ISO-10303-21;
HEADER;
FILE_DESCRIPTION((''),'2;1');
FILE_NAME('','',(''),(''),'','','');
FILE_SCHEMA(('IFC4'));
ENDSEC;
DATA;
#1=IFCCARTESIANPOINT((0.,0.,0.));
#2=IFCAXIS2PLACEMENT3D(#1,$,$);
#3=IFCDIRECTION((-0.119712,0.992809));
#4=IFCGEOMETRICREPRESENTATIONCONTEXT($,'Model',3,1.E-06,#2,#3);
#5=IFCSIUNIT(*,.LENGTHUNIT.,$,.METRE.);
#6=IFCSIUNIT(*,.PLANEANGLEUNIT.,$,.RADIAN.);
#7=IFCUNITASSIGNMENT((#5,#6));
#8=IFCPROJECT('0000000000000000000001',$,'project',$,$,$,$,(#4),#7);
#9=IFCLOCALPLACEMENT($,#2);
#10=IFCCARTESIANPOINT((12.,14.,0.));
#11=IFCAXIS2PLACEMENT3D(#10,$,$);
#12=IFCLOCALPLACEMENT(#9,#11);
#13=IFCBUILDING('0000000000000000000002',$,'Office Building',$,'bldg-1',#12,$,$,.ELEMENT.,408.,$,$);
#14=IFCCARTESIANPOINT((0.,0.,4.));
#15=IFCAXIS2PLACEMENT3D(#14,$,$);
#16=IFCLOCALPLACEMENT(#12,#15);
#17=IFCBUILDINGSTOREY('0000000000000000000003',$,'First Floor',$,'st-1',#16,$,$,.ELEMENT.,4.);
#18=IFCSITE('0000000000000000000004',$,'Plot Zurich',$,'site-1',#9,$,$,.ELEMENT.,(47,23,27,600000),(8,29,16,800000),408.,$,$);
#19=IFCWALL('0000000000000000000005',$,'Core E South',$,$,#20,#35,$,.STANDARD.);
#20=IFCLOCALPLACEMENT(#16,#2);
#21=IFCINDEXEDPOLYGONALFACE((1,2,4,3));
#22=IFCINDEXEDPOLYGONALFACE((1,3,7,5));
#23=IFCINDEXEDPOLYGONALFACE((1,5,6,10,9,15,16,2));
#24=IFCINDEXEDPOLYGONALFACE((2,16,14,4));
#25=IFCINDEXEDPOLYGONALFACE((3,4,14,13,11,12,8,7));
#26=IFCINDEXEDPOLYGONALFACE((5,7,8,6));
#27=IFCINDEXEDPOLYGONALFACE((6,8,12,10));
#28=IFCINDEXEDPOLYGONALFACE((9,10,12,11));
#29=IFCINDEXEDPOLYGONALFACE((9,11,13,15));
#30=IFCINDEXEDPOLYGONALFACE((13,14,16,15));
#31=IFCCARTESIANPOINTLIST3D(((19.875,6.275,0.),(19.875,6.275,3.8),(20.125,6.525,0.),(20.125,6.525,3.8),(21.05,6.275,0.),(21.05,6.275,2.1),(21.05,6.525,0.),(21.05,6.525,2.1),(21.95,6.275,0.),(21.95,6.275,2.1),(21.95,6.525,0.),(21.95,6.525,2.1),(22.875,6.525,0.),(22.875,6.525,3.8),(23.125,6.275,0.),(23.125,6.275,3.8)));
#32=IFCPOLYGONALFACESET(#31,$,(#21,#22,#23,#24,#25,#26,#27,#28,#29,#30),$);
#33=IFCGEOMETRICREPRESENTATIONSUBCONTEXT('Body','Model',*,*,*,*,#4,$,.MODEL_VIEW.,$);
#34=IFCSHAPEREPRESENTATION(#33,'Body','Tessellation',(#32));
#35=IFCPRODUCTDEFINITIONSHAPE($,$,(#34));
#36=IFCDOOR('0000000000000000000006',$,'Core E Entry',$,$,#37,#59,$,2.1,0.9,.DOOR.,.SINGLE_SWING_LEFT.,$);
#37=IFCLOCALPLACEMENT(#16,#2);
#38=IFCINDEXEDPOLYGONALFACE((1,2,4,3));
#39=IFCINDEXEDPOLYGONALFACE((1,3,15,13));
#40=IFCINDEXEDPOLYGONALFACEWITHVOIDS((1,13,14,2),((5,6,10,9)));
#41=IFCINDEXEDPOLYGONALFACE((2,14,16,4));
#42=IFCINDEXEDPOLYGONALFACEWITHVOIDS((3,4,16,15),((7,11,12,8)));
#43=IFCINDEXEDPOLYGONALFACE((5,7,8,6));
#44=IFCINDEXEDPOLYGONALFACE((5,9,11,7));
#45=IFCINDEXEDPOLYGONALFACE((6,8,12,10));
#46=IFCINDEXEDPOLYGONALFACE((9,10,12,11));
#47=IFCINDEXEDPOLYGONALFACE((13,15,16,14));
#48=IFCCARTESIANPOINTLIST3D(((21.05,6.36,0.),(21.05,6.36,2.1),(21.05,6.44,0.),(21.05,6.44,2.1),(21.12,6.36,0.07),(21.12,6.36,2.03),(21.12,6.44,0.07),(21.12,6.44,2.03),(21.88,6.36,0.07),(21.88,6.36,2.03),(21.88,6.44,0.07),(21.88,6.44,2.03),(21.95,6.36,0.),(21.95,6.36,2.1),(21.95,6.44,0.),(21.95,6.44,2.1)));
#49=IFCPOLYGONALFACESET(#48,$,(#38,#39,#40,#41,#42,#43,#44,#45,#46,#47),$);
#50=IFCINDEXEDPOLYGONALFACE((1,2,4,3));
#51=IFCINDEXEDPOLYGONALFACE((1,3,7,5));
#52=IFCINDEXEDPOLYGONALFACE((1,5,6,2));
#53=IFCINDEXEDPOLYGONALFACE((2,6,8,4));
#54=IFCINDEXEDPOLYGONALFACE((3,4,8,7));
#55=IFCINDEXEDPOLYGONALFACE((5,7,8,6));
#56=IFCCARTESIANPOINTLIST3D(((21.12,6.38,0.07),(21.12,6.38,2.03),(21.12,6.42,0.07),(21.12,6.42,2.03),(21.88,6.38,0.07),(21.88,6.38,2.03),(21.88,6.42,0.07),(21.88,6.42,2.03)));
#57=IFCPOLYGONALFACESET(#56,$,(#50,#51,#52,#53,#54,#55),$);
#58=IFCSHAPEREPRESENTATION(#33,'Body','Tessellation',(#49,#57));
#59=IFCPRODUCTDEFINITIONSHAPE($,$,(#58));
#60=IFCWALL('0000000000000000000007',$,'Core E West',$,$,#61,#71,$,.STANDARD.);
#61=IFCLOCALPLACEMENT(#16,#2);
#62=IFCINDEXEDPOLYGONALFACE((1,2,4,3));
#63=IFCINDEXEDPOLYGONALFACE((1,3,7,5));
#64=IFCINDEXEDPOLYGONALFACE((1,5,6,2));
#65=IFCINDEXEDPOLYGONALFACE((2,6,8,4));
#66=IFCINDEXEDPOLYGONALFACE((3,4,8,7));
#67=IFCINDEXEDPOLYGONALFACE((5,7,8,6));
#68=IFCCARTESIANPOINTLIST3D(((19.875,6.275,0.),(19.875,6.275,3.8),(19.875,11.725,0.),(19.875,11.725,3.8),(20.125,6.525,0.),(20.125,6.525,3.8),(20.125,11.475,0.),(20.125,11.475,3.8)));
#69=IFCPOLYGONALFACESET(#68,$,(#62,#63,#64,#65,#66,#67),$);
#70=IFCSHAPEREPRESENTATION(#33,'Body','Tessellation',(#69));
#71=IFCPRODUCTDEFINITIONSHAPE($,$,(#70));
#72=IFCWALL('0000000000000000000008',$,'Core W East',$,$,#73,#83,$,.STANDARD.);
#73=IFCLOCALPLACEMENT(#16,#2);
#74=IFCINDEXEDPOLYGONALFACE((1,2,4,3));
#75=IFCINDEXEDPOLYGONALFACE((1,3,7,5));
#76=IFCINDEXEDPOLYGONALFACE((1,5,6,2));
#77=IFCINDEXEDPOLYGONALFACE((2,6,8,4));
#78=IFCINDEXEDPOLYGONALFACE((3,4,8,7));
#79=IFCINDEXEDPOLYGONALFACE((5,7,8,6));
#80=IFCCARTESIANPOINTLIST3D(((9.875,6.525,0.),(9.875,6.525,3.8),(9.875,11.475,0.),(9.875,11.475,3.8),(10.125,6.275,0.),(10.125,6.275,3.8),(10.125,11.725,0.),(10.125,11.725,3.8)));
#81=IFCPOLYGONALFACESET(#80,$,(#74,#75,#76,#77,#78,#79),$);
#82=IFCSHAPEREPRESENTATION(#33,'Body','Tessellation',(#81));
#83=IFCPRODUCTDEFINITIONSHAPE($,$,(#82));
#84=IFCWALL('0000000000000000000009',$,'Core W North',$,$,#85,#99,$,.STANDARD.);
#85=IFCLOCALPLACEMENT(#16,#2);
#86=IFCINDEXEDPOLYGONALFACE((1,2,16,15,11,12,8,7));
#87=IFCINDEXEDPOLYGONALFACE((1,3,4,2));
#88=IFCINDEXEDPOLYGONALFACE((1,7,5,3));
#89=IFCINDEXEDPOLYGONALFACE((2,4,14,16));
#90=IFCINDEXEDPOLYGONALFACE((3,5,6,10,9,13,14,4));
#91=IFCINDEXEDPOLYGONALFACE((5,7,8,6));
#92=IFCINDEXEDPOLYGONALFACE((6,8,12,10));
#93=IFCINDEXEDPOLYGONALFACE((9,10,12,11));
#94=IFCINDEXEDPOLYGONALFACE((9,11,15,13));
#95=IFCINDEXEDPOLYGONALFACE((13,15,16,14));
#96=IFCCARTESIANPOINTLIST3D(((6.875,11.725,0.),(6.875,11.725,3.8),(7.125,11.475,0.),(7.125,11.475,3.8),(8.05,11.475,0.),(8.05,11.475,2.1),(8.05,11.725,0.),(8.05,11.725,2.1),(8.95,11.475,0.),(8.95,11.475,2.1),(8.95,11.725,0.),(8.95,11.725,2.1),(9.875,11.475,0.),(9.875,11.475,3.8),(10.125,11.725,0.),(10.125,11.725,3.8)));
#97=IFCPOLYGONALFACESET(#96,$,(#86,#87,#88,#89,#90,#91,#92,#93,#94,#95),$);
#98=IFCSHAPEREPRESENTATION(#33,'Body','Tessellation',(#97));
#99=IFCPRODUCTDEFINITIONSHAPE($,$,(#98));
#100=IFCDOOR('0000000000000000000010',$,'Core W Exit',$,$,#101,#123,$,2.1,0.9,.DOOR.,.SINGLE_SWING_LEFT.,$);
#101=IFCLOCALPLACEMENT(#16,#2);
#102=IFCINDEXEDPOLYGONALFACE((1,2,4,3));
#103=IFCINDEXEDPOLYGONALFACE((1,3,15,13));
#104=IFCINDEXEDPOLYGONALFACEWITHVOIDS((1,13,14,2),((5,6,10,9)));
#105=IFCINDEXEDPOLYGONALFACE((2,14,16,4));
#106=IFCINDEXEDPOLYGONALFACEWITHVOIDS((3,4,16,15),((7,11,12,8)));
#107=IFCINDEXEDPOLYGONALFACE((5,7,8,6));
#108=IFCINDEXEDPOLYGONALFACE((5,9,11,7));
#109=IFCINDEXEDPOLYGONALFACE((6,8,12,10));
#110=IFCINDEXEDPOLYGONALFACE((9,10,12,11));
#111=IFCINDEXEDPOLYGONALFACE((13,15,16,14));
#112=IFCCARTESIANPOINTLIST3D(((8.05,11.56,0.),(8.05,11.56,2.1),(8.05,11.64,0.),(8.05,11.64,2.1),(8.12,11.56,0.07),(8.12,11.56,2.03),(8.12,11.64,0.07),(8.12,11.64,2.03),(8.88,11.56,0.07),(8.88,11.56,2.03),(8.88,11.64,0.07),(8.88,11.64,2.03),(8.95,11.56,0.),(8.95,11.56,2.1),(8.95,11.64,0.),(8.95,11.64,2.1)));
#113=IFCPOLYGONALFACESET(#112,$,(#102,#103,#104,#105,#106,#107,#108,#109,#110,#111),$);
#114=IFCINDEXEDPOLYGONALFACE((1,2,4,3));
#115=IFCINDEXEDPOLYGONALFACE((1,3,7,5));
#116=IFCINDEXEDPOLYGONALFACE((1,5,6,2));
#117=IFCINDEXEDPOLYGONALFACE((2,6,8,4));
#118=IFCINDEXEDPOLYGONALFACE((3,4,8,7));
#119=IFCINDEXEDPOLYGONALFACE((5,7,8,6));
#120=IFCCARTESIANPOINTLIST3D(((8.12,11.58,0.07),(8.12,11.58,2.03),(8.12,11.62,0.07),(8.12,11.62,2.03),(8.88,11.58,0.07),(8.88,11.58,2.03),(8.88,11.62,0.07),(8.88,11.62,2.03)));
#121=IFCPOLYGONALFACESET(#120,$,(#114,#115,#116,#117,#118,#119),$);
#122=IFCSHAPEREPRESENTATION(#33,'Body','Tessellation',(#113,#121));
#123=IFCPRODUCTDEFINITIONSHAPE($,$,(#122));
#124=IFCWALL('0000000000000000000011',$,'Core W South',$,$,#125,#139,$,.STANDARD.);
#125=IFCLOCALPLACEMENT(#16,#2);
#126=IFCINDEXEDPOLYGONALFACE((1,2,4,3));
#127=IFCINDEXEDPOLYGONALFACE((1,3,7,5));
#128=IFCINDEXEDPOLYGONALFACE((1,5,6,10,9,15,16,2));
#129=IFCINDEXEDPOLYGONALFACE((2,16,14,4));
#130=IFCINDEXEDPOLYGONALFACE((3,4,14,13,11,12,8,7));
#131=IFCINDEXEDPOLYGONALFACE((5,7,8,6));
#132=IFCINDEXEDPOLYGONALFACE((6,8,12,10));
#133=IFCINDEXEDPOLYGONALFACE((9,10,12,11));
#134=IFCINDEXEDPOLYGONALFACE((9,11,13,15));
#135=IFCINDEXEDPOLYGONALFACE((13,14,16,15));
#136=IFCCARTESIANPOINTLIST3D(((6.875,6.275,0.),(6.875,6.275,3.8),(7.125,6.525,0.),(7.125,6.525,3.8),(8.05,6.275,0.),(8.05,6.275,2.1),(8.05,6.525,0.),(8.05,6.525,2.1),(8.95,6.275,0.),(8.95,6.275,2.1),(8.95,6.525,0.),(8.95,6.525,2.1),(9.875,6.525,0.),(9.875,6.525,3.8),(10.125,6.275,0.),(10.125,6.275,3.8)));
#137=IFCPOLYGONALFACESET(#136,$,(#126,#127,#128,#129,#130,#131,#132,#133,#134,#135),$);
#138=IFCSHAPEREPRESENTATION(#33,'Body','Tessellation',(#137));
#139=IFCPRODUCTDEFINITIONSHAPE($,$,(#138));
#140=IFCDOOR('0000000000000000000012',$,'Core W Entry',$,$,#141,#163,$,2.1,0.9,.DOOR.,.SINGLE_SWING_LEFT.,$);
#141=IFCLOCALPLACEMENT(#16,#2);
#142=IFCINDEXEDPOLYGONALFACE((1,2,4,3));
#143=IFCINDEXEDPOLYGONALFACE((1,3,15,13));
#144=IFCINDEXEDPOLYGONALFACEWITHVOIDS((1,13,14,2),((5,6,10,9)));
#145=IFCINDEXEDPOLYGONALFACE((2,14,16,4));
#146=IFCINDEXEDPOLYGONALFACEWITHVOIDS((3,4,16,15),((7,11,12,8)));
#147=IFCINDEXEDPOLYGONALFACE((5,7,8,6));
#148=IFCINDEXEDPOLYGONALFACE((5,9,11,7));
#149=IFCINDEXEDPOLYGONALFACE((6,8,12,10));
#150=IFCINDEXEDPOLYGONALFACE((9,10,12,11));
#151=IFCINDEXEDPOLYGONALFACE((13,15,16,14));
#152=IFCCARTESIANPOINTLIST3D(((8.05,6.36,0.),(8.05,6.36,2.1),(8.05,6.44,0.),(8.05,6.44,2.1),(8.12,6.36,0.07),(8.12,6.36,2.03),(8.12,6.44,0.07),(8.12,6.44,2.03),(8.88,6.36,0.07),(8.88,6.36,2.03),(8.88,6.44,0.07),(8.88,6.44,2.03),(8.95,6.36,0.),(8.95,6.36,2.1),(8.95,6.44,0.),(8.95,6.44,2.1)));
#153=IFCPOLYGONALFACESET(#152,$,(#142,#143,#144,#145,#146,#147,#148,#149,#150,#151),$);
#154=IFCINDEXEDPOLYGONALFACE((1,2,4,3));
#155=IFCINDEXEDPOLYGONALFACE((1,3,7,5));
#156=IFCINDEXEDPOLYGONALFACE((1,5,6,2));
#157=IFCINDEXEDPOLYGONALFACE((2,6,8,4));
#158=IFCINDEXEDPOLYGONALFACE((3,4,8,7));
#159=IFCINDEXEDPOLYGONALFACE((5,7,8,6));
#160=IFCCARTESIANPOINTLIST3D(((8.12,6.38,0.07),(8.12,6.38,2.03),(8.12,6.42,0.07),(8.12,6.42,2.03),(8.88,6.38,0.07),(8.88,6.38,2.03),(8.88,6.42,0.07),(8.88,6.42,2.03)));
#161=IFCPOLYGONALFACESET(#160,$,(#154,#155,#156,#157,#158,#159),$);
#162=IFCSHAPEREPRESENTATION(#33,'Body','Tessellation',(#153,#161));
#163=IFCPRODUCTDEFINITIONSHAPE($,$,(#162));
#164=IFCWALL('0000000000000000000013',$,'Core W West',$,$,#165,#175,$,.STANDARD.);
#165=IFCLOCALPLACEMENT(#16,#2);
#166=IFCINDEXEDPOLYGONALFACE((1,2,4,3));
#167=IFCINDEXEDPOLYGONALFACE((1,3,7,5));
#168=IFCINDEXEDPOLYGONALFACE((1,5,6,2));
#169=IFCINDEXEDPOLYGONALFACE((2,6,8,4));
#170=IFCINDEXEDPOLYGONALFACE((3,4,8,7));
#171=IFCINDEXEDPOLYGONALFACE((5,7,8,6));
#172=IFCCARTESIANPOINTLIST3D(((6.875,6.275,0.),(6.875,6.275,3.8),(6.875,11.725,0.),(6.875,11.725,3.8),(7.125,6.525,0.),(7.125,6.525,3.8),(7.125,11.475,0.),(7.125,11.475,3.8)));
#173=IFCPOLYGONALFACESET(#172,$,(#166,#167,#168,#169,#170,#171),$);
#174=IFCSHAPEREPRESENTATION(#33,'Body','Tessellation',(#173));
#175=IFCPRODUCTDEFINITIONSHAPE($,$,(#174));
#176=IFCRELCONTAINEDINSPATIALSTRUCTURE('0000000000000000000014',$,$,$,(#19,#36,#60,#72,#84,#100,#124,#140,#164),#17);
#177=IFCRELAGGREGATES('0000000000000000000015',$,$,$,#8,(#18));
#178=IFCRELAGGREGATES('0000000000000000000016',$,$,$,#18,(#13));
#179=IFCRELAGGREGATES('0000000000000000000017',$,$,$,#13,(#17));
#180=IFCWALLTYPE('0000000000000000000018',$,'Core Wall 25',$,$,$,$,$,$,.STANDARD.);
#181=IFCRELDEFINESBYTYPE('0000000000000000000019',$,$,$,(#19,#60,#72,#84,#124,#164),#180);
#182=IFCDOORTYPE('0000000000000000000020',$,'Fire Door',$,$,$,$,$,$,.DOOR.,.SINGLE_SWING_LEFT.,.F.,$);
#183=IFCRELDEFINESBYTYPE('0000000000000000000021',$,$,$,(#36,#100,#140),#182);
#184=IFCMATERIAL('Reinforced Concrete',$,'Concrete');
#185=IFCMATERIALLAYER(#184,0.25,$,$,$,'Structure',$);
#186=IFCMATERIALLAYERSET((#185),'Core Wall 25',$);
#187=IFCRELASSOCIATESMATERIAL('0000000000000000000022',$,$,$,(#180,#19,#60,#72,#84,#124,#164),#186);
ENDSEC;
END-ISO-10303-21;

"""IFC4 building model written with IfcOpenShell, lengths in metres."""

from ifc_helpers import new_model, si_unit, direction, frame, frame_2d, origin, origin_2d, place, context, subcontext, project, spatial, polyline, rectangle, outline, extrude, material, layer, layer_set, layer_usage, type_object, element, fill, save


model = new_model("IFC4")

# Units and contexts
model_context = context("Model", 3, precision=1e-06, world=origin(), true_north=direction((-0.119712, 0.992809)))
body_context = subcontext(model_context, "Body", "Model", "MODEL_VIEW")
ifc_project = project(units=[si_unit("LENGTHUNIT", "METRE"), si_unit("PLANEANGLEUNIT", "RADIAN")], contexts=[model_context])

# Site, building, storey
site_placement = place(None, origin())
site = spatial("IfcSite", under=ifc_project, at=site_placement, Name="Plot Zurich", ObjectType="site-1", CompositionType="ELEMENT", RefLatitude=(47, 23, 27, 600000), RefLongitude=(8, 29, 16, 800000), RefElevation=408.0)
building_placement = place(site_placement, frame((12.0, 14.0, 0.0)))
building = spatial("IfcBuilding", under=site, at=building_placement, Name="Office Building", ObjectType="bldg-1", CompositionType="ELEMENT", ElevationOfRefHeight=408.0)
storey_placement = place(building_placement, frame((0.0, 0.0, 4.0)))
storey = spatial("IfcBuildingStorey", under=building, at=storey_placement, Name="First Floor", ObjectType="st-1", CompositionType="ELEMENT", Elevation=4.0)

# Shared definitions
ifc_material_1 = material(Name="Reinforced Concrete", Category="Concrete")

# Shared definitions
ifc_layer_1 = layer(ifc_material_1, 0.25, Category="Structure")
ifc_layer_set_1 = layer_set([ifc_layer_1], Name="Core Wall 25")
wall_type_1 = type_object("IfcWallType", Name="Core Wall 25", PredefinedType="STANDARD", material=ifc_layer_set_1)

# Wall, opening, door
door_type = type_object("IfcDoorType", Name="Fire Door", OperationType="SINGLE_SWING_LEFT", ParameterTakesPrecedence=False, PredefinedType="DOOR")
ifc_layer_usage_1 = layer_usage(ifc_layer_set_1, "AXIS2", "NEGATIVE", 0.125)
wall_1_placement = place(storey_placement, origin())
wall_1 = element("IfcWall", 1, at=wall_1_placement, inside=storey, type_object=wall_type_1, material=ifc_layer_usage_1, Name="Core E South", PredefinedType="STANDARD", context=body_context, shape_type="SweptSolid", body=[
    extrude(outline(polyline([(19.875, 6.275), (23.125, 6.275), (22.875, 6.525), (20.125, 6.525), (19.875, 6.275)])), origin(), (0.0, 0.0, 1.0), 3.8),
])
opening_1_placement = place(wall_1_placement, frame((21.5, 6.4, 0.0), z_axis=(0.0, 0.0, 1.0), x_axis=(1.0, 0.0, 0.0)))
opening_1 = element("IfcOpeningElement", 2, at=opening_1_placement, cuts=wall_1, PredefinedType="OPENING", context=body_context, shape_type="SweptSolid", body=[
    extrude(rectangle(XDim=0.9, YDim=0.25, at=origin_2d()), origin(), (0.0, 0.0, 1.0), 2.1),
])
door_1_placement = place(opening_1_placement, frame((0.0, 0.0, 0.0), z_axis=(0.0, -1.0, 0.0), x_axis=(1.0, 0.0, 0.0)))
door_1 = element("IfcDoor", 3, at=door_1_placement, inside=storey, type_object=door_type, Name="Core E Entry", OperationType="SINGLE_SWING_LEFT", OverallHeight=2.1, OverallWidth=0.9, PredefinedType="DOOR", context=body_context, shape_type="SweptSolid", body=[
    extrude(outline(polyline([(-0.45, 0.0), (0.45, 0.0), (0.45, 2.1), (-0.45, 2.1), (-0.45, 0.0)]), holes=[polyline([(-0.38, 0.07), (0.38, 0.07), (0.38, 2.03), (-0.38, 2.03), (-0.38, 0.07)])]), frame((0.0, 0.0, -0.04)), (0.0, 0.0, 1.0), 0.08),
    extrude(rectangle(XDim=0.76, YDim=1.96, at=frame_2d((0.0, 1.05))), frame((0.0, 0.0, -0.02)), (0.0, 0.0, 1.0), 0.04),
])
fill(opening_1, door_1)

# Walls
ifc_layer_usage_2 = layer_usage(ifc_layer_set_1, "AXIS2", "NEGATIVE", 0.125)
wall_2_placement = place(storey_placement, origin())
element("IfcWall", 4, at=wall_2_placement, inside=storey, type_object=wall_type_1, material=ifc_layer_usage_2, Name="Core E West", PredefinedType="STANDARD", context=body_context, shape_type="SweptSolid", body=[
    extrude(outline(polyline([(19.875, 11.725), (19.875, 6.275), (20.125, 6.525), (20.125, 11.475), (19.875, 11.725)])), origin(), (0.0, 0.0, 1.0), 3.8),
])
ifc_layer_usage_3 = layer_usage(ifc_layer_set_1, "AXIS2", "NEGATIVE", 0.125)
wall_3_placement = place(storey_placement, origin())
element("IfcWall", 5, at=wall_3_placement, inside=storey, type_object=wall_type_1, material=ifc_layer_usage_3, Name="Core W East", PredefinedType="STANDARD", context=body_context, shape_type="SweptSolid", body=[
    extrude(outline(polyline([(10.125, 6.275), (10.125, 11.725), (9.875, 11.475), (9.875, 6.525), (10.125, 6.275)])), origin(), (0.0, 0.0, 1.0), 3.8),
])

# Walls, openings, doors
ifc_layer_usage_4 = layer_usage(ifc_layer_set_1, "AXIS2", "NEGATIVE", 0.125)
wall_4_placement = place(storey_placement, origin())
wall_4 = element("IfcWall", 6, at=wall_4_placement, inside=storey, type_object=wall_type_1, material=ifc_layer_usage_4, Name="Core W North", PredefinedType="STANDARD", context=body_context, shape_type="SweptSolid", body=[
    extrude(outline(polyline([(10.125, 11.725), (6.875, 11.725), (7.125, 11.475), (9.875, 11.475), (10.125, 11.725)])), origin(), (0.0, 0.0, 1.0), 3.8),
])
opening_2_placement = place(wall_4_placement, frame((8.5, 11.6, 0.0), z_axis=(0.0, 0.0, 1.0), x_axis=(-1.0, 0.0, 0.0)))
opening_2 = element("IfcOpeningElement", 7, at=opening_2_placement, cuts=wall_4, PredefinedType="OPENING", context=body_context, shape_type="SweptSolid", body=[
    extrude(rectangle(XDim=0.9, YDim=0.25, at=origin_2d()), origin(), (0.0, 0.0, 1.0), 2.1),
])
door_2_placement = place(opening_2_placement, frame((0.0, 0.0, 0.0), z_axis=(0.0, -1.0, 0.0), x_axis=(1.0, 0.0, 0.0)))
door_2 = element("IfcDoor", 8, at=door_2_placement, inside=storey, type_object=door_type, Name="Core W Exit", OperationType="SINGLE_SWING_LEFT", OverallHeight=2.1, OverallWidth=0.9, PredefinedType="DOOR", context=body_context, shape_type="SweptSolid", body=[
    extrude(outline(polyline([(-0.45, 0.0), (0.45, 0.0), (0.45, 2.1), (-0.45, 2.1), (-0.45, 0.0)]), holes=[polyline([(-0.38, 0.07), (0.38, 0.07), (0.38, 2.03), (-0.38, 2.03), (-0.38, 0.07)])]), frame((0.0, 0.0, -0.04)), (0.0, 0.0, 1.0), 0.08),
    extrude(rectangle(XDim=0.76, YDim=1.96, at=frame_2d((0.0, 1.05))), frame((0.0, 0.0, -0.02)), (0.0, 0.0, 1.0), 0.04),
])
fill(opening_2, door_2)
ifc_layer_usage_5 = layer_usage(ifc_layer_set_1, "AXIS2", "NEGATIVE", 0.125)
wall_5_placement = place(storey_placement, origin())
wall_5 = element("IfcWall", 9, at=wall_5_placement, inside=storey, type_object=wall_type_1, material=ifc_layer_usage_5, Name="Core W South", PredefinedType="STANDARD", context=body_context, shape_type="SweptSolid", body=[
    extrude(outline(polyline([(6.875, 6.275), (10.125, 6.275), (9.875, 6.525), (7.125, 6.525), (6.875, 6.275)])), origin(), (0.0, 0.0, 1.0), 3.8),
])
opening_3_placement = place(wall_5_placement, frame((8.5, 6.4, 0.0), z_axis=(0.0, 0.0, 1.0), x_axis=(1.0, 0.0, 0.0)))
opening_3 = element("IfcOpeningElement", 10, at=opening_3_placement, cuts=wall_5, PredefinedType="OPENING", context=body_context, shape_type="SweptSolid", body=[
    extrude(rectangle(XDim=0.9, YDim=0.25, at=origin_2d()), origin(), (0.0, 0.0, 1.0), 2.1),
])
door_3_placement = place(opening_3_placement, frame((0.0, 0.0, 0.0), z_axis=(0.0, -1.0, 0.0), x_axis=(1.0, 0.0, 0.0)))
door_3 = element("IfcDoor", 11, at=door_3_placement, inside=storey, type_object=door_type, Name="Core W Entry", OperationType="SINGLE_SWING_LEFT", OverallHeight=2.1, OverallWidth=0.9, PredefinedType="DOOR", context=body_context, shape_type="SweptSolid", body=[
    extrude(outline(polyline([(-0.45, 0.0), (0.45, 0.0), (0.45, 2.1), (-0.45, 2.1), (-0.45, 0.0)]), holes=[polyline([(-0.38, 0.07), (0.38, 0.07), (0.38, 2.03), (-0.38, 2.03), (-0.38, 0.07)])]), frame((0.0, 0.0, -0.04)), (0.0, 0.0, 1.0), 0.08),
    extrude(rectangle(XDim=0.76, YDim=1.96, at=frame_2d((0.0, 1.05))), frame((0.0, 0.0, -0.02)), (0.0, 0.0, 1.0), 0.04),
])
fill(opening_3, door_3)

# Wall
ifc_layer_usage_6 = layer_usage(ifc_layer_set_1, "AXIS2", "NEGATIVE", 0.125)
wall_6_placement = place(storey_placement, origin())
element("IfcWall", 12, at=wall_6_placement, inside=storey, type_object=wall_type_1, material=ifc_layer_usage_6, Name="Core W West", PredefinedType="STANDARD", context=body_context, shape_type="SweptSolid", body=[
    extrude(outline(polyline([(6.875, 11.725), (6.875, 6.275), (7.125, 6.525), (7.125, 11.475), (6.875, 11.725)])), origin(), (0.0, 0.0, 1.0), 3.8),
])

save(model, "model.ifc")
